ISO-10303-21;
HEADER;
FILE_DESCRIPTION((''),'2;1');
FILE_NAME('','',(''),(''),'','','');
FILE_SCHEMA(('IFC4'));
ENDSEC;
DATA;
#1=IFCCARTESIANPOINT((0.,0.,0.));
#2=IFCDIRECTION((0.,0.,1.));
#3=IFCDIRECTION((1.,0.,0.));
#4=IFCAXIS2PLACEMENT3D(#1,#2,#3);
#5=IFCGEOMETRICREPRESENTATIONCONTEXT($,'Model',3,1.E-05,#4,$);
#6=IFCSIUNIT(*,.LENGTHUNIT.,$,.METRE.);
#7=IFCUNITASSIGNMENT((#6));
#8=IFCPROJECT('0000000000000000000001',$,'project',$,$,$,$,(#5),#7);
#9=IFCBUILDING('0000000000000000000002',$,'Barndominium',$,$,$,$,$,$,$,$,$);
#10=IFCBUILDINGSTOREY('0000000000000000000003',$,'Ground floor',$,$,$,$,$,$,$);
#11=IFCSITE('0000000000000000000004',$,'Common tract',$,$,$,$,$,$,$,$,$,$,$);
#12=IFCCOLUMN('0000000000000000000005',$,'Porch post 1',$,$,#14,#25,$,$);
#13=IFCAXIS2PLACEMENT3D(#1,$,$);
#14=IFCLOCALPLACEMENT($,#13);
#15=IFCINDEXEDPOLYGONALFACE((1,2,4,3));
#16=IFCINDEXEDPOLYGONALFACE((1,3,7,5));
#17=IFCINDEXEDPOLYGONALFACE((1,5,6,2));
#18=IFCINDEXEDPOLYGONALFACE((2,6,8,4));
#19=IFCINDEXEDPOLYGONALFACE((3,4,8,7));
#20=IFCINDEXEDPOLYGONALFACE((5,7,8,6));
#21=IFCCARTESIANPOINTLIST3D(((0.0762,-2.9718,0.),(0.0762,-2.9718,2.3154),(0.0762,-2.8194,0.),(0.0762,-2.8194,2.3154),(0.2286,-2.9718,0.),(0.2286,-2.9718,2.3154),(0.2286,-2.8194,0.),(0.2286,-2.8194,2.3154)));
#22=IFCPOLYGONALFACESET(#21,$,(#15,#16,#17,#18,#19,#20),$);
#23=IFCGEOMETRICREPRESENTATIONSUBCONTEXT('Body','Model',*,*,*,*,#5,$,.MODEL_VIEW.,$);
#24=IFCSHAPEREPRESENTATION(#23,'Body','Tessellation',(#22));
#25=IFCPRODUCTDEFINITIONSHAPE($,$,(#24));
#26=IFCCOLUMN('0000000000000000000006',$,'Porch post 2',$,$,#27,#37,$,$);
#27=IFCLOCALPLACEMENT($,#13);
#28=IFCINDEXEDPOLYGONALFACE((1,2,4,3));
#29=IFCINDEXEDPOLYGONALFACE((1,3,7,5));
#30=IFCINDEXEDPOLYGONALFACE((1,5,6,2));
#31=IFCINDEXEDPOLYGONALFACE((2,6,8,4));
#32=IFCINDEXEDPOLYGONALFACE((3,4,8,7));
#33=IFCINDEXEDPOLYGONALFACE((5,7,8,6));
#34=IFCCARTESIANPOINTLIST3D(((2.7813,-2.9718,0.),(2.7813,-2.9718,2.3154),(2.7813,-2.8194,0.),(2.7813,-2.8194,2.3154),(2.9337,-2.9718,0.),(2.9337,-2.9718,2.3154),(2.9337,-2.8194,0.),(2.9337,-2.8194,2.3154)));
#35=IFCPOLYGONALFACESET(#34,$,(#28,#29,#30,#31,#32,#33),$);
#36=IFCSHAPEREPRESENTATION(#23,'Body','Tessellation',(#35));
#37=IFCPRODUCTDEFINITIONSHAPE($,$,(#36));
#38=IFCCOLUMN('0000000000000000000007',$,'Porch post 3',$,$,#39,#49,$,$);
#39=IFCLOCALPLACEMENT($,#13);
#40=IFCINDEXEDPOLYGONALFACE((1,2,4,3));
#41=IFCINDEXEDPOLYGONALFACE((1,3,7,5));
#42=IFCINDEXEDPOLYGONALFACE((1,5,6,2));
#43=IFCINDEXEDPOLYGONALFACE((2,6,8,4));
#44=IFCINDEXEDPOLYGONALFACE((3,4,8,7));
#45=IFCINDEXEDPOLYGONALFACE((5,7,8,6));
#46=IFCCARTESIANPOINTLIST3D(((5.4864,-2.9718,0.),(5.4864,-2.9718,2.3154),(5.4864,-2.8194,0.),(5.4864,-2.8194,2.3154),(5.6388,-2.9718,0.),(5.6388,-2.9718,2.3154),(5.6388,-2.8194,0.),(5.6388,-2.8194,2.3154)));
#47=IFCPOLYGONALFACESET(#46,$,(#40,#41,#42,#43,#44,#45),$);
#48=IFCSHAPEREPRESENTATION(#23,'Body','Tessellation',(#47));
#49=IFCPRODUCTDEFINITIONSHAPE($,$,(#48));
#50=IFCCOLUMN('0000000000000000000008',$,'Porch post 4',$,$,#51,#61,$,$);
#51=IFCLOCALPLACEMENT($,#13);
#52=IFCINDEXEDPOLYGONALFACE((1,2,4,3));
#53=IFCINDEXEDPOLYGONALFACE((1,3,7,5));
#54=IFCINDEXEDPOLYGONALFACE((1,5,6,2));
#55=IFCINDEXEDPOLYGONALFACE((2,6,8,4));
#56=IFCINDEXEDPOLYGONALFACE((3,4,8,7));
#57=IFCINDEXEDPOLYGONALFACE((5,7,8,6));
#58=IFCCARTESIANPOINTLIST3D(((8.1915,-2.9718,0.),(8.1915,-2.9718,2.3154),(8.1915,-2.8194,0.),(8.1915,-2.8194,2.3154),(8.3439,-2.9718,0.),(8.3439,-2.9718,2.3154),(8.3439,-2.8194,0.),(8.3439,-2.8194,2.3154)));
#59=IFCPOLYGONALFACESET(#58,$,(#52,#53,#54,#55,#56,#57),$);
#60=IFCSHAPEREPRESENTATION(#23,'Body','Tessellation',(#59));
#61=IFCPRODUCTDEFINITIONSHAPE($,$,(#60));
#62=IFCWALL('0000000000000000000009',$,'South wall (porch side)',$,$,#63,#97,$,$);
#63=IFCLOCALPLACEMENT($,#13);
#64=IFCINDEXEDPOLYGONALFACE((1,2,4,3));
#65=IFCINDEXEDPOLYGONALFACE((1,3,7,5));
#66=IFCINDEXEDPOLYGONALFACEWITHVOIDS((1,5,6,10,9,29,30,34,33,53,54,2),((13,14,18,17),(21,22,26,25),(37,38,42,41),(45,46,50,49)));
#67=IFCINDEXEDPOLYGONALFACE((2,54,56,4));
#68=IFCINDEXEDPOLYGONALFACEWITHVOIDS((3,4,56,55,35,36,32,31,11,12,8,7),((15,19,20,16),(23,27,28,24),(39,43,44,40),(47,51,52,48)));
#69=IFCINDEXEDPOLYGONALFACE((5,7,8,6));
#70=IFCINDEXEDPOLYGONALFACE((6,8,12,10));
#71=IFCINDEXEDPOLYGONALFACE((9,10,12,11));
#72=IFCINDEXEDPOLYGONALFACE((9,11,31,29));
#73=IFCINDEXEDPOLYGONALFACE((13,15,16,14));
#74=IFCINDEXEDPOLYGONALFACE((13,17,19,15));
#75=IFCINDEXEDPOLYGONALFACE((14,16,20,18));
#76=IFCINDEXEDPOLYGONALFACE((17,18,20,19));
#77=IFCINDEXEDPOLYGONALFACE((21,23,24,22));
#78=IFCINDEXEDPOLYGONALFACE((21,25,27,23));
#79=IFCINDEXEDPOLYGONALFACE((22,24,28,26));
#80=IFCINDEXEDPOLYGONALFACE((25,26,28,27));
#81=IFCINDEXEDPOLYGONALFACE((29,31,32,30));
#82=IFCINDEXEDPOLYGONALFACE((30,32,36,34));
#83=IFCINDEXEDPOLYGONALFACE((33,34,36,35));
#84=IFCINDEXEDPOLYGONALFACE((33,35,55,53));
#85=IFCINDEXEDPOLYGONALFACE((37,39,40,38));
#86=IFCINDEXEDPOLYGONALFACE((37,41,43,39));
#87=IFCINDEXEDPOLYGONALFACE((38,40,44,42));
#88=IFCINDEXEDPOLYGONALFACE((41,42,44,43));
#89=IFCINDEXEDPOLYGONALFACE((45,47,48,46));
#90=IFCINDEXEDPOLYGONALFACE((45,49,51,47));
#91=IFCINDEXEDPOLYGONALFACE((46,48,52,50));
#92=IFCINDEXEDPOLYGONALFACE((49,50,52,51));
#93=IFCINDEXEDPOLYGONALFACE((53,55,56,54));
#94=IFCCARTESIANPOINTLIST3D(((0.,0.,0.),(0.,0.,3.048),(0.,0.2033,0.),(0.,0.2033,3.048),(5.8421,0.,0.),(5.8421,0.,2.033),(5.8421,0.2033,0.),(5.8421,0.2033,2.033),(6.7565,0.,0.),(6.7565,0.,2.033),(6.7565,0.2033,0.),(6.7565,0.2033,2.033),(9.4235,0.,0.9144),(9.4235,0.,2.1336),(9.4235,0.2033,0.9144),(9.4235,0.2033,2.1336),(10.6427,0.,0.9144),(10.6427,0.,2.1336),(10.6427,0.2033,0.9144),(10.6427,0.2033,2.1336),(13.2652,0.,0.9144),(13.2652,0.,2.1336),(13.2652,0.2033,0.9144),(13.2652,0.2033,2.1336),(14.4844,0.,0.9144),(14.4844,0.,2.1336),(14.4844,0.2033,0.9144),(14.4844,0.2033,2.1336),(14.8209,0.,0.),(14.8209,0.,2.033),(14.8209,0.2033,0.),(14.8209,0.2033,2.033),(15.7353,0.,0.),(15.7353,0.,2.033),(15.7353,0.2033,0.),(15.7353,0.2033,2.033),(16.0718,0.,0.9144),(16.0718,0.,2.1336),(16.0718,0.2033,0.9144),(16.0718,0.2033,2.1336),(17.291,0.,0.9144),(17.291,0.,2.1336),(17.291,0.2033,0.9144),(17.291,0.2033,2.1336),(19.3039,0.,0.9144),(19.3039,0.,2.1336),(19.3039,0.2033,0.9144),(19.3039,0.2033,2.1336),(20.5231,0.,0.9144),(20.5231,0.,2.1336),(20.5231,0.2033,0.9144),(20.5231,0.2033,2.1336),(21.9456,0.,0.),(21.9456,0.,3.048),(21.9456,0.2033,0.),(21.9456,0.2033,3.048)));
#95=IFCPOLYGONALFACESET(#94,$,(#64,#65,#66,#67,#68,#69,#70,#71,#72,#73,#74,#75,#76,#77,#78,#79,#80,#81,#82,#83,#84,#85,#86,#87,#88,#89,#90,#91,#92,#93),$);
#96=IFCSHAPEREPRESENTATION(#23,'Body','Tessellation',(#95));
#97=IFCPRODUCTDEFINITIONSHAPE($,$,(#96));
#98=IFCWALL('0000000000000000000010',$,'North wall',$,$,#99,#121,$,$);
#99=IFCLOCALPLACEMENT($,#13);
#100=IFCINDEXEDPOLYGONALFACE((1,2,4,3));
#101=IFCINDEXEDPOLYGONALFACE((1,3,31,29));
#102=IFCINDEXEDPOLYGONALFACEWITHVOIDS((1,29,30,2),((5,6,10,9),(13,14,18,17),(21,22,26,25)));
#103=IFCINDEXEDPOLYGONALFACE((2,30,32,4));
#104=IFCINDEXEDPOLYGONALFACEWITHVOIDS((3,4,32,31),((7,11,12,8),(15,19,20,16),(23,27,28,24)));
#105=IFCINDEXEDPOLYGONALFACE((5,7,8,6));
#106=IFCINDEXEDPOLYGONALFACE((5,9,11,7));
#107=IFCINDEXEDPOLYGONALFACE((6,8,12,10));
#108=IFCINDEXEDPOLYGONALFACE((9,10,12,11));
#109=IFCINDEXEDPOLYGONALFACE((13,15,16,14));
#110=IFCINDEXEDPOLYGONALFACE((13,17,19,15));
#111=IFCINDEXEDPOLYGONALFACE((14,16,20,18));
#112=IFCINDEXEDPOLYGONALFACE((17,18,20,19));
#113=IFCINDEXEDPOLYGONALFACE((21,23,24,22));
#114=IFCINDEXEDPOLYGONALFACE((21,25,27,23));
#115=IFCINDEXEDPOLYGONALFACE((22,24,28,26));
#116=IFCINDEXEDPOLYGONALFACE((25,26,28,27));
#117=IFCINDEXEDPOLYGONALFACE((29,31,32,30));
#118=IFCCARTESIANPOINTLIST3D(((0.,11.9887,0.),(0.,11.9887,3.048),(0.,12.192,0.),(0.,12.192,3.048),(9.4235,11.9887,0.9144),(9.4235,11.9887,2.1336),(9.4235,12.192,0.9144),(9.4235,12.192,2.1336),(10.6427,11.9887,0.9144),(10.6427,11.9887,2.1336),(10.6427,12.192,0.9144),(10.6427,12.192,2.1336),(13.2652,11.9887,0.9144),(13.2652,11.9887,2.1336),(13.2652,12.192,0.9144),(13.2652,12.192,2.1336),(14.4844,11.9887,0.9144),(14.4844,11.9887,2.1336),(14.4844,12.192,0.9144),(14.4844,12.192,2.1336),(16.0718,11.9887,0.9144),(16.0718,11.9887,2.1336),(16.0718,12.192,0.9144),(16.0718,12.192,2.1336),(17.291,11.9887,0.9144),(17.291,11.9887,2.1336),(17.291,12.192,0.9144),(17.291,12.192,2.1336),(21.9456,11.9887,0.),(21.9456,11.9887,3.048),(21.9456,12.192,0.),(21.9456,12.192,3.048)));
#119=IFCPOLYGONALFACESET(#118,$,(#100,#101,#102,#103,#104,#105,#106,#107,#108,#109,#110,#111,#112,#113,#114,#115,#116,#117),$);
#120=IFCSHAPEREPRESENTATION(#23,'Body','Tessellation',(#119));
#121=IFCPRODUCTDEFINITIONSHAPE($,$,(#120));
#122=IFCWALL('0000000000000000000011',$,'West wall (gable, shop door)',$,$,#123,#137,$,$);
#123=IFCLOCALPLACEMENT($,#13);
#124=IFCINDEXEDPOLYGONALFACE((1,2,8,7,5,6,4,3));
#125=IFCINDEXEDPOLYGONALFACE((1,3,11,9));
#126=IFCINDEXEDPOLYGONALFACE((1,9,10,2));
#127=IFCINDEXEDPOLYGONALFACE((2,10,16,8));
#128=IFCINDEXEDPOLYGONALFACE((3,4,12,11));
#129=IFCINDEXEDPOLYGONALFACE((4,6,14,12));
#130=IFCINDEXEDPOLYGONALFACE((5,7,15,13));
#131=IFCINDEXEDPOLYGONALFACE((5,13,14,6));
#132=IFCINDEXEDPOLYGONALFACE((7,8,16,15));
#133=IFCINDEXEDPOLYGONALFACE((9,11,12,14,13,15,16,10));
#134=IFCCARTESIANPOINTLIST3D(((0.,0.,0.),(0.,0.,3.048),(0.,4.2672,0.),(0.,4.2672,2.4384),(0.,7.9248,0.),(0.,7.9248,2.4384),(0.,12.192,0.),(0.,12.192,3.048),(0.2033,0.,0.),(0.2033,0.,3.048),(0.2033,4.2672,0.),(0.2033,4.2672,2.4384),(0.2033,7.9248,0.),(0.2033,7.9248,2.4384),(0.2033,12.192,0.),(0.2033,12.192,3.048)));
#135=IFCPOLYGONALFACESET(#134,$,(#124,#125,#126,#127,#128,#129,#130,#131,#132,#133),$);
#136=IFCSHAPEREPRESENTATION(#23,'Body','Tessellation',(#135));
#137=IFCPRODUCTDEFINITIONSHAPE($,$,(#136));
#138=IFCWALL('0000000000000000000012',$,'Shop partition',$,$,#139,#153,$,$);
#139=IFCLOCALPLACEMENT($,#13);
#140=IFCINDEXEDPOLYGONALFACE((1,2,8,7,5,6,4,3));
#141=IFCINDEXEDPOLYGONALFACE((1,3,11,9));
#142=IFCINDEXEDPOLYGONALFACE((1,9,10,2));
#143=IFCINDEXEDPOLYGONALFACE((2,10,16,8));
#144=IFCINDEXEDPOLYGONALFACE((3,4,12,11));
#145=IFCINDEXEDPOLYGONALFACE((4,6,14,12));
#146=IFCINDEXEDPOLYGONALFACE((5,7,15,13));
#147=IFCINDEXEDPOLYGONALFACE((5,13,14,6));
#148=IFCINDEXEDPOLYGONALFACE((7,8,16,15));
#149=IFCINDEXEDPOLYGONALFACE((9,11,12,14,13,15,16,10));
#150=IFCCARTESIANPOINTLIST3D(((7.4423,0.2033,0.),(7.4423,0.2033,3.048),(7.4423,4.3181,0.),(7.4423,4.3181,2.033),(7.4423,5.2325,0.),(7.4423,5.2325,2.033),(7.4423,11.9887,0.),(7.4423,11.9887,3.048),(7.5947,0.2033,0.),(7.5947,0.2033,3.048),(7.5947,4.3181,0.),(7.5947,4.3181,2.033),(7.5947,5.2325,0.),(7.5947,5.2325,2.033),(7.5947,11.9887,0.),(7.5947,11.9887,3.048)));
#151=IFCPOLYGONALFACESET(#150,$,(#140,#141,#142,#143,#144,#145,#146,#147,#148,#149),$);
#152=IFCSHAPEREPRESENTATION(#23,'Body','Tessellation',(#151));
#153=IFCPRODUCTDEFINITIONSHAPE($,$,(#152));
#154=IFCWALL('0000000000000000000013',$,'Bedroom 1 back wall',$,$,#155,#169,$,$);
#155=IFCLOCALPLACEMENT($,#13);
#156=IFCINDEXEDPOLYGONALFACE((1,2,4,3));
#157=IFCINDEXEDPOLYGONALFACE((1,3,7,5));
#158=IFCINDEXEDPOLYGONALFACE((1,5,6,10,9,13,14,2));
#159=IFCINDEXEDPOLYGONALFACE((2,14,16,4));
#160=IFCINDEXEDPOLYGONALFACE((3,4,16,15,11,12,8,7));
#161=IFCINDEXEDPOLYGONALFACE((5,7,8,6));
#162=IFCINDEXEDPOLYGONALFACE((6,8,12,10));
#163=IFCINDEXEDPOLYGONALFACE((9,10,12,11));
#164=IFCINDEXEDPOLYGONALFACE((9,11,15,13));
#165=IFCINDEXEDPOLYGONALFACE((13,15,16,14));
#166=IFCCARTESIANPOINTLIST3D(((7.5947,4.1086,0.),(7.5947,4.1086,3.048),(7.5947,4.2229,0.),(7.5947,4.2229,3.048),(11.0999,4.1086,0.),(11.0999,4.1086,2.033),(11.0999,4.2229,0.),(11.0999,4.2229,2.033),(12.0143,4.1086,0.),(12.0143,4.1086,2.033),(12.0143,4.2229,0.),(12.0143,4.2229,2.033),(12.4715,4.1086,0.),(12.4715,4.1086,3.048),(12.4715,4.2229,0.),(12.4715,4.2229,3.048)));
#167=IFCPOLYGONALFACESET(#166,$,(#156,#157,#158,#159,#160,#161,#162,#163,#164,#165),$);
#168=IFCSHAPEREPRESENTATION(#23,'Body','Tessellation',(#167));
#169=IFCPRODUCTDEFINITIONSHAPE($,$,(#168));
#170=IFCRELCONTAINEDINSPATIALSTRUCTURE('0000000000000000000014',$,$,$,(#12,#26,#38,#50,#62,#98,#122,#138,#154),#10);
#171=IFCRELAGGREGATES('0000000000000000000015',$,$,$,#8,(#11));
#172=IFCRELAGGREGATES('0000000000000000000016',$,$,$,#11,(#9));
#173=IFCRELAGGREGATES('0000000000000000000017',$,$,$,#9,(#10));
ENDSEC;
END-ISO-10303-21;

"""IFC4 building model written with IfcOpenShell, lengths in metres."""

from ifc_helpers import new_model, si_unit, frame, origin_with_axes, place, context, subcontext, project, spatial, indexed_curve, rectangle, outline, extrude, element, save


model = new_model("IFC4")

# Units and contexts
model_context = context("Model", 3, precision=1e-05, world=origin_with_axes())
body_context = subcontext(model_context, "Body", "Model", "MODEL_VIEW")
ifc_project = project(units=[si_unit("LENGTHUNIT", "METRE")], contexts=[model_context])

# Site, building, storey
site = spatial("IfcSite", under=ifc_project, Name="Common tract")
building = spatial("IfcBuilding", under=site, Name="Barndominium")
storey = spatial("IfcBuildingStorey", under=building, Name="Ground floor")

# Columns
for number, where, z_axis, x_axis, name in (
    (1, (0.1524, -2.8956, 0.0), (0.0, 0.0, 1.0), (1.0, 0.0, 0.0), "Porch post 1"),
    (2, (2.8575, -2.8956, 0.0), (0.0, 0.0, 1.0), (1.0, 0.0, 0.0), "Porch post 2"),
    (3, (5.5626, -2.8956, 0.0), (0.0, 0.0, 1.0), (1.0, 0.0, 0.0), "Porch post 3"),
    (4, (8.2677, -2.8956, 0.0), (0.0, 0.0, 1.0), (1.0, 0.0, 0.0), "Porch post 4"),
):
    element("IfcColumn", number, at=place(None, frame(where, z_axis=z_axis, x_axis=x_axis)), inside=storey, Name=name, context=body_context, shape_type="SweptSolid", body=[
        extrude(rectangle(XDim=0.1524, YDim=0.1524), origin_with_axes(), (0.0, 0.0, 1.0), 2.3154),
    ])

# Walls, openings
wall_1_placement = place(None, origin_with_axes())
wall_1 = element("IfcWall", 5, at=wall_1_placement, inside=storey, Name="South wall (porch side)", context=body_context, shape_type="SweptSolid", body=[
    extrude(outline(indexed_curve([(0.0, 0.0), (0.0, 0.2033), (21.9456, 0.2033), (21.9456, 0.0), (0.0, 0.0)], self_intersect=False)), origin_with_axes(), (0.0, 0.0, 1.0), 3.048),
])
opening_1_placement = place(wall_1_placement, frame((6.2993, 0.1017, 0.0), z_axis=(0.0, 0.0, 1.0), x_axis=(1.0, 0.0, 0.0)))
element("IfcOpeningElement", 6, at=opening_1_placement, cuts=wall_1, context=body_context, shape_type="SweptSolid", body=[
    extrude(rectangle(XDim=0.9144, YDim=0.3033), origin_with_axes(), (0.0, 0.0, 1.0), 2.033),
])
opening_2_placement = place(wall_1_placement, frame((15.2781, 0.1017, 0.0), z_axis=(0.0, 0.0, 1.0), x_axis=(1.0, 0.0, 0.0)))
element("IfcOpeningElement", 7, at=opening_2_placement, cuts=wall_1, context=body_context, shape_type="SweptSolid", body=[
    extrude(rectangle(XDim=0.9144, YDim=0.3033), origin_with_axes(), (0.0, 0.0, 1.0), 2.033),
])
opening_3_placement = place(wall_1_placement, frame((10.0331, 0.1017, 0.9144), z_axis=(0.0, 0.0, 1.0), x_axis=(1.0, 0.0, 0.0)))
element("IfcOpeningElement", 8, at=opening_3_placement, cuts=wall_1, context=body_context, shape_type="SweptSolid", body=[
    extrude(rectangle(XDim=1.2192, YDim=0.3033), origin_with_axes(), (0.0, 0.0, 1.0), 1.2192),
])
opening_4_placement = place(wall_1_placement, frame((13.8748, 0.1017, 0.9144), z_axis=(0.0, 0.0, 1.0), x_axis=(1.0, 0.0, 0.0)))
element("IfcOpeningElement", 9, at=opening_4_placement, cuts=wall_1, context=body_context, shape_type="SweptSolid", body=[
    extrude(rectangle(XDim=1.2192, YDim=0.3033), origin_with_axes(), (0.0, 0.0, 1.0), 1.2192),
])
opening_5_placement = place(wall_1_placement, frame((16.6814, 0.1017, 0.9144), z_axis=(0.0, 0.0, 1.0), x_axis=(1.0, 0.0, 0.0)))
element("IfcOpeningElement", 10, at=opening_5_placement, cuts=wall_1, context=body_context, shape_type="SweptSolid", body=[
    extrude(rectangle(XDim=1.2192, YDim=0.3033), origin_with_axes(), (0.0, 0.0, 1.0), 1.2192),
])
opening_6_placement = place(wall_1_placement, frame((19.9135, 0.1017, 0.9144), z_axis=(0.0, 0.0, 1.0), x_axis=(1.0, 0.0, 0.0)))
element("IfcOpeningElement", 11, at=opening_6_placement, cuts=wall_1, context=body_context, shape_type="SweptSolid", body=[
    extrude(rectangle(XDim=1.2192, YDim=0.3033), origin_with_axes(), (0.0, 0.0, 1.0), 1.2192),
])
wall_2_placement = place(None, frame((0.0, 11.9887, 0.0), z_axis=(0.0, 0.0, 1.0), x_axis=(1.0, 0.0, 0.0)))
wall_2 = element("IfcWall", 12, at=wall_2_placement, inside=storey, Name="North wall", context=body_context, shape_type="SweptSolid", body=[
    extrude(outline(indexed_curve([(0.0, 0.0), (0.0, 0.2033), (21.9456, 0.2033), (21.9456, 0.0), (0.0, 0.0)], self_intersect=False)), origin_with_axes(), (0.0, 0.0, 1.0), 3.048),
])
opening_7_placement = place(wall_2_placement, frame((10.0331, 0.1017, 0.9144), z_axis=(0.0, 0.0, 1.0), x_axis=(1.0, 0.0, 0.0)))
element("IfcOpeningElement", 13, at=opening_7_placement, cuts=wall_2, context=body_context, shape_type="SweptSolid", body=[
    extrude(rectangle(XDim=1.2192, YDim=0.3033), origin_with_axes(), (0.0, 0.0, 1.0), 1.2192),
])
opening_8_placement = place(wall_2_placement, frame((13.8748, 0.1017, 0.9144), z_axis=(0.0, 0.0, 1.0), x_axis=(1.0, 0.0, 0.0)))
element("IfcOpeningElement", 14, at=opening_8_placement, cuts=wall_2, context=body_context, shape_type="SweptSolid", body=[
    extrude(rectangle(XDim=1.2192, YDim=0.3033), origin_with_axes(), (0.0, 0.0, 1.0), 1.2192),
])
opening_9_placement = place(wall_2_placement, frame((16.6814, 0.1017, 0.9144), z_axis=(0.0, 0.0, 1.0), x_axis=(1.0, 0.0, 0.0)))
element("IfcOpeningElement", 15, at=opening_9_placement, cuts=wall_2, context=body_context, shape_type="SweptSolid", body=[
    extrude(rectangle(XDim=1.2192, YDim=0.3033), origin_with_axes(), (0.0, 0.0, 1.0), 1.2192),
])

# Walls, openings
wall_3_placement = place(None, frame((0.2033, 0.0, 0.0), z_axis=(0.0, 0.0, 1.0), x_axis=(0.0, 1.0, 0.0)))
wall_3 = element("IfcWall", 16, at=wall_3_placement, inside=storey, Name="West wall (gable, shop door)", context=body_context, shape_type="SweptSolid", body=[
    extrude(outline(indexed_curve([(0.0, 0.0), (0.0, 0.2033), (12.192, 0.2033), (12.192, 0.0), (0.0, 0.0)], self_intersect=False)), origin_with_axes(), (0.0, 0.0, 1.0), 3.048),
])
opening_10_placement = place(wall_3_placement, frame((6.096, 0.1017, 0.0), z_axis=(0.0, 0.0, 1.0), x_axis=(0.0, -1.0, 0.0)))
element("IfcOpeningElement", 17, at=opening_10_placement, cuts=wall_3, context=body_context, shape_type="SweptSolid", body=[
    extrude(rectangle(XDim=0.3033, YDim=3.6576), origin_with_axes(), (0.0, 0.0, 1.0), 2.4384),
])
wall_4_placement = place(None, frame((7.5947, 0.2033, 0.0), z_axis=(0.0, 0.0, 1.0), x_axis=(0.0, 1.0, 0.0)))
wall_4 = element("IfcWall", 18, at=wall_4_placement, inside=storey, Name="Shop partition", context=body_context, shape_type="SweptSolid", body=[
    extrude(outline(indexed_curve([(0.0, 0.0), (0.0, 0.1524), (11.7854, 0.1524), (11.7854, 0.0), (0.0, 0.0)], self_intersect=False)), origin_with_axes(), (0.0, 0.0, 1.0), 3.048),
])
opening_11_placement = place(wall_4_placement, frame((4.572, 0.0762, 0.0), z_axis=(0.0, 0.0, 1.0), x_axis=(0.0, -1.0, 0.0)))
element("IfcOpeningElement", 19, at=opening_11_placement, cuts=wall_4, context=body_context, shape_type="SweptSolid", body=[
    extrude(rectangle(XDim=0.3033, YDim=0.9144), origin_with_axes(), (0.0, 0.0, 1.0), 2.033),
])
wall_5_placement = place(None, frame((7.5947, 4.1086, 0.0), z_axis=(0.0, 0.0, 1.0), x_axis=(1.0, 0.0, 0.0)))
wall_5 = element("IfcWall", 20, at=wall_5_placement, inside=storey, Name="Bedroom 1 back wall", context=body_context, shape_type="SweptSolid", body=[
    extrude(outline(indexed_curve([(0.0, 0.0), (0.0, 0.1143), (4.8768, 0.1143), (4.8768, 0.0), (0.0, 0.0)], self_intersect=False)), origin_with_axes(), (0.0, 0.0, 1.0), 3.048),
])
opening_12_placement = place(wall_5_placement, frame((3.9624, 0.0572, 0.0), z_axis=(0.0, 0.0, 1.0), x_axis=(1.0, 0.0, 0.0)))
element("IfcOpeningElement", 21, at=opening_12_placement, cuts=wall_5, context=body_context, shape_type="SweptSolid", body=[
    extrude(rectangle(XDim=0.9144, YDim=0.3033), origin_with_axes(), (0.0, 0.0, 1.0), 2.033),
])

save(model, "model.ifc")
